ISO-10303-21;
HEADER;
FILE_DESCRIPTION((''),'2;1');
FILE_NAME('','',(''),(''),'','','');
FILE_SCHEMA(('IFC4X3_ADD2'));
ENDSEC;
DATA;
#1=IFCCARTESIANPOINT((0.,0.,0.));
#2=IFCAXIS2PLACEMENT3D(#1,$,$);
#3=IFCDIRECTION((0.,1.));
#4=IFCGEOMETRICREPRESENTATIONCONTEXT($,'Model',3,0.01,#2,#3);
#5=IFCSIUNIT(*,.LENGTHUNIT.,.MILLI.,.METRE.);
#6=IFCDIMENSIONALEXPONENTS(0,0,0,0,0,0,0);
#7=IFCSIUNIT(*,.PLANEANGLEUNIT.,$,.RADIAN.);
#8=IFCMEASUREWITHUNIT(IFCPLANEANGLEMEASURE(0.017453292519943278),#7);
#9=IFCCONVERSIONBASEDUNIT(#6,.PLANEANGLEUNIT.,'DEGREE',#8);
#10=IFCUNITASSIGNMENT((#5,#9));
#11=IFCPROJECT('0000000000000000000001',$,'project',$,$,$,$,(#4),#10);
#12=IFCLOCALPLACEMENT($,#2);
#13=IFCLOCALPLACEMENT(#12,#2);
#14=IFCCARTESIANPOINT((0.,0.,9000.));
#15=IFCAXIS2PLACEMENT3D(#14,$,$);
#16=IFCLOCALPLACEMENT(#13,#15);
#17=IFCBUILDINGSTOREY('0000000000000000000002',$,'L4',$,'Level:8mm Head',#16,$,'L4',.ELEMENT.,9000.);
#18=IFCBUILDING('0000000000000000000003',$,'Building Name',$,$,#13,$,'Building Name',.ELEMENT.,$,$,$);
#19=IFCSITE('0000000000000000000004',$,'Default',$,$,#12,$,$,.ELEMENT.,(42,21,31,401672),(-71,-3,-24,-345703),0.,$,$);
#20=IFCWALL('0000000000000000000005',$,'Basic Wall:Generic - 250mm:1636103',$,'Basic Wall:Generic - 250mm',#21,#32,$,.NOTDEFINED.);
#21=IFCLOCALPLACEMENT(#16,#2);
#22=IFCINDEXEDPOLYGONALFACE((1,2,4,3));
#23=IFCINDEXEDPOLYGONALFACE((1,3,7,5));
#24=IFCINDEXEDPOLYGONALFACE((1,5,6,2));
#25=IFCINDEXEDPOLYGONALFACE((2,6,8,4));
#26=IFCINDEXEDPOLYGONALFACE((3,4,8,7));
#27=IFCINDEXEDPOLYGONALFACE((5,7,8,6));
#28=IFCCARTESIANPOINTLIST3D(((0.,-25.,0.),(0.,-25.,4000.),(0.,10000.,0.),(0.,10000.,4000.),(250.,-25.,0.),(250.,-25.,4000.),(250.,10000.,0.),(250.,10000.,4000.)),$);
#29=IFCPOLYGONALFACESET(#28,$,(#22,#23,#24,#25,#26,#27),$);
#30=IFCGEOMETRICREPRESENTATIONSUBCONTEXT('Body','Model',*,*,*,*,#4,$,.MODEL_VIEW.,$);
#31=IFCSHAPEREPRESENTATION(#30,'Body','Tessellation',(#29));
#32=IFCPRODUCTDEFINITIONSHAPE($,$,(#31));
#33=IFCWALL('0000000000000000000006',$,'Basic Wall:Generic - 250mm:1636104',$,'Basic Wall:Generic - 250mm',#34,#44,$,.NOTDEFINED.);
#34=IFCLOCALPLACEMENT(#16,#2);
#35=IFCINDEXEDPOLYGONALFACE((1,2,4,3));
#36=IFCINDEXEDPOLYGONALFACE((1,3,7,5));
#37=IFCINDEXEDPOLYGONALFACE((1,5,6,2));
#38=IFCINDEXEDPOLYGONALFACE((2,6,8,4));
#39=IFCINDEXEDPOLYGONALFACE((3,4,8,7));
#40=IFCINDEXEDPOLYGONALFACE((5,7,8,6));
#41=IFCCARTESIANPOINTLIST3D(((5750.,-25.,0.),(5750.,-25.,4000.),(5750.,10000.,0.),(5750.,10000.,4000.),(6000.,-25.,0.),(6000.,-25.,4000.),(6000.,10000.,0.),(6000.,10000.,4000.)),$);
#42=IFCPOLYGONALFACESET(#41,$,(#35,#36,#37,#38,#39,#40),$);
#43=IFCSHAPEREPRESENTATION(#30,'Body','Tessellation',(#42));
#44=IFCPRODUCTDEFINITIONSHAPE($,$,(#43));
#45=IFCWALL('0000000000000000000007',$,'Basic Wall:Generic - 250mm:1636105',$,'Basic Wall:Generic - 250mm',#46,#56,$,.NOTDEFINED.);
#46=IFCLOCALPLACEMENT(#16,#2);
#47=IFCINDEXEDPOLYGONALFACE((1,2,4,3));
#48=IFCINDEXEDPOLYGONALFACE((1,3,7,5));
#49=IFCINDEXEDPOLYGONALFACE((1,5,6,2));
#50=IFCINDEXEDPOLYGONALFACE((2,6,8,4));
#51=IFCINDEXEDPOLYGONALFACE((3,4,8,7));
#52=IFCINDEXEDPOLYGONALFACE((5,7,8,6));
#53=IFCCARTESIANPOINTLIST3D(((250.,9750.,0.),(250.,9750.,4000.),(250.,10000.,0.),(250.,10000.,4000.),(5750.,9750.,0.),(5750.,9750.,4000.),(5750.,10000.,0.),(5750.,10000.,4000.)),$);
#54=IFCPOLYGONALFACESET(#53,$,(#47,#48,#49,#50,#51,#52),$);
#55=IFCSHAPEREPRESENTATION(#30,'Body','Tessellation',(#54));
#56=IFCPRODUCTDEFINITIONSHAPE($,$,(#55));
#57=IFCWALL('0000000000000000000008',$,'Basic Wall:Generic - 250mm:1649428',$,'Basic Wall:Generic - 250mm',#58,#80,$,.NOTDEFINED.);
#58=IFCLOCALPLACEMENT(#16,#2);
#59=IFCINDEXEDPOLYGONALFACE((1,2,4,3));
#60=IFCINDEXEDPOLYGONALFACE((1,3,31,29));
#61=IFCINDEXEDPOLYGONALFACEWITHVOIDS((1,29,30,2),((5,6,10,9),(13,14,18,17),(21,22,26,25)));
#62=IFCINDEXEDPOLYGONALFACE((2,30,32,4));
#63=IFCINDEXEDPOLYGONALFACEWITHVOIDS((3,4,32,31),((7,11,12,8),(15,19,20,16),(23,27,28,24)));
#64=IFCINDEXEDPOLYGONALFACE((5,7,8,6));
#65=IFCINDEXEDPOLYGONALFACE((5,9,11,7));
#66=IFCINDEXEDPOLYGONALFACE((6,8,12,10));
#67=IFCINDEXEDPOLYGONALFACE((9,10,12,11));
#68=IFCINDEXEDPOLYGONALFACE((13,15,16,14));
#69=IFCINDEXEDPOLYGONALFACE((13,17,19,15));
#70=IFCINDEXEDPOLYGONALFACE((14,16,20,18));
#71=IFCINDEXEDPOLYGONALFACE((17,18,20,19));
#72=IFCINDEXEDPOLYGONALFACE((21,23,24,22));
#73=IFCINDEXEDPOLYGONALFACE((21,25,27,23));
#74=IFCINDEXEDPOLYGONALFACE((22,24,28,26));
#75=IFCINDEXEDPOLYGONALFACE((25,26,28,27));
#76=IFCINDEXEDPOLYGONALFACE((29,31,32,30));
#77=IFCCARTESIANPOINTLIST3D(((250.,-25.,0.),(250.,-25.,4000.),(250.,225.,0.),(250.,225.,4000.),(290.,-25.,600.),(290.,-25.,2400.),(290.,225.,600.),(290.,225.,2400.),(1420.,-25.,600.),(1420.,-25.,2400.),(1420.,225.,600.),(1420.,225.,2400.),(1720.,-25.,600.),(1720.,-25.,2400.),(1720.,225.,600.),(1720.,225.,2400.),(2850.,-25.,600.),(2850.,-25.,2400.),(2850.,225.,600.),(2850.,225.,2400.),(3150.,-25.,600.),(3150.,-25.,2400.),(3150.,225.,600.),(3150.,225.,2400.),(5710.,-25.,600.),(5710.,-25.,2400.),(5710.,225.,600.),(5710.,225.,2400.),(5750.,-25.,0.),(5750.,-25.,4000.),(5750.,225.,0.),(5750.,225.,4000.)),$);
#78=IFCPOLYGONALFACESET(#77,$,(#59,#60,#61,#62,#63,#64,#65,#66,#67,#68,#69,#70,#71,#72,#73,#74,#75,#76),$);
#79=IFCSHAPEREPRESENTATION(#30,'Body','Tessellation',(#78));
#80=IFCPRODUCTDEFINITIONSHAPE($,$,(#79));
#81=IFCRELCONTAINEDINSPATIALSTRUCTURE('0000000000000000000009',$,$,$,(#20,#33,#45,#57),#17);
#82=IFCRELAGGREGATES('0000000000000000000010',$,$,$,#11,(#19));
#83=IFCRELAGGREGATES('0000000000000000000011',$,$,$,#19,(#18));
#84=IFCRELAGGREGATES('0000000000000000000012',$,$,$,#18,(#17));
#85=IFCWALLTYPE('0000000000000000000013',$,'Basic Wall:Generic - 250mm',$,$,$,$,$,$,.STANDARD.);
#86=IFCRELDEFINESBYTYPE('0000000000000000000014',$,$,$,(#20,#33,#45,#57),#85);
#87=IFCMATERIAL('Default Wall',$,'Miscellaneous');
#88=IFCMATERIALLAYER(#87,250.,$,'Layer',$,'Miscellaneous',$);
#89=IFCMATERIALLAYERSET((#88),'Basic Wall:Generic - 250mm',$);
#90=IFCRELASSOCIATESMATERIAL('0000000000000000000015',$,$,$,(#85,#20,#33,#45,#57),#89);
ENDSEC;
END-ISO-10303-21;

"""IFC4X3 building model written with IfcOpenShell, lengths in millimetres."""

from ifc_helpers import new_model, entity, si_unit, converted_unit, direction, frame, frame_2d, origin, place, context, subcontext, project, spatial, rectangle, extrude, material, layer, layer_set, type_object, element, save


model = new_model("IFC4X3")

# Units and contexts
model_context = context("Model", 3, precision=0.01, world=origin(), true_north=direction((0.0, 1.0)))
body_context = subcontext(model_context, "Body", "Model", "MODEL_VIEW")
ifc_project = project(units=[si_unit("LENGTHUNIT", "METRE", prefix="MILLI"), converted_unit("PLANEANGLEUNIT", "DEGREE", entity("IfcPlaneAngleMeasure", 0.017453292519943278), si_unit("PLANEANGLEUNIT", "RADIAN"), dimensions=[0, 0, 0, 0, 0, 0, 0])], contexts=[model_context])

# Site, building, storey
site_placement = place(None, origin())
site = spatial("IfcSite", under=ifc_project, at=site_placement, Name="Default", CompositionType="ELEMENT", RefLatitude=(42, 21, 31, 401672), RefLongitude=(-71, -3, -24, -345703), RefElevation=0.0)
building_placement = place(site_placement, origin())
building = spatial("IfcBuilding", under=site, at=building_placement, Name="Building Name", LongName="Building Name", CompositionType="ELEMENT")
storey_placement = place(building_placement, frame((0.0, 0.0, 9000.0)))
storey = spatial("IfcBuildingStorey", under=building, at=storey_placement, Name="L4", ObjectType="Level:8mm Head", LongName="L4", CompositionType="ELEMENT", Elevation=9000.0)

# Walls
ifc_material = material(Name="Default Wall", Category="Miscellaneous")
ifc_layer = layer(ifc_material, 250.0, Name="Layer", Category="Miscellaneous")
ifc_layer_set = layer_set([ifc_layer], Name="Basic Wall:Generic - 250mm")
wall_type = type_object("IfcWallType", Name="Basic Wall:Generic - 250mm", PredefinedType="STANDARD", material=ifc_layer_set)
wall_1_placement = place(storey_placement, frame((125.0, 10000.0, 0.0), z_axis=(0.0, 0.0, 1.0), x_axis=(0.0, -1.0, 0.0)))
element("IfcWall", 1, at=wall_1_placement, inside=storey, type_object=wall_type, material=ifc_layer_set, Name="Basic Wall:Generic - 250mm:1636103", ObjectType="Basic Wall:Generic - 250mm", PredefinedType="NOTDEFINED", context=body_context, shape_type="SweptSolid", body=[
    extrude(rectangle(XDim=10025.0, YDim=250.0, at=frame_2d((5012.5, 0.0), x_axis=(-1.0, 0.0))), origin(), (0.0, 0.0, 1.0), 4000.0),
])
wall_2_placement = place(storey_placement, frame((5875.0, -25.0, 0.0), z_axis=(0.0, 0.0, 1.0), x_axis=(0.0, 1.0, 0.0)))
element("IfcWall", 2, at=wall_2_placement, inside=storey, type_object=wall_type, material=ifc_layer_set, Name="Basic Wall:Generic - 250mm:1636104", ObjectType="Basic Wall:Generic - 250mm", PredefinedType="NOTDEFINED", context=body_context, shape_type="SweptSolid", body=[
    extrude(rectangle(XDim=10025.0, YDim=250.0, at=frame_2d((5012.5, 0.0), x_axis=(-1.0, 0.0))), origin(), (0.0, 0.0, 1.0), 4000.0),
])
wall_3_placement = place(storey_placement, frame((5750.0, 9875.0, 0.0), z_axis=(0.0, 0.0, 1.0), x_axis=(-1.0, 0.0, 0.0)))
element("IfcWall", 3, at=wall_3_placement, inside=storey, type_object=wall_type, material=ifc_layer_set, Name="Basic Wall:Generic - 250mm:1636105", ObjectType="Basic Wall:Generic - 250mm", PredefinedType="NOTDEFINED", context=body_context, shape_type="SweptSolid", body=[
    extrude(rectangle(XDim=5500.0, YDim=250.0, at=frame_2d((2750.0, 0.0), x_axis=(-1.0, 0.0))), origin(), (0.0, 0.0, 1.0), 4000.0),
])

# Wall, openings
wall_4_placement = place(storey_placement, frame((250.0, 100.0, 0.0)))
wall_4 = element("IfcWall", 4, at=wall_4_placement, inside=storey, type_object=wall_type, material=ifc_layer_set, Name="Basic Wall:Generic - 250mm:1649428", ObjectType="Basic Wall:Generic - 250mm", PredefinedType="NOTDEFINED", context=body_context, shape_type="SweptSolid", body=[
    extrude(rectangle(XDim=5500.0, YDim=250.0, at=frame_2d((2750.0, 0.0), x_axis=(-1.0, 0.0))), origin(), (0.0, 0.0, 1.0), 4000.0),
])
opening_1_placement = place(wall_4_placement, frame((1470.0, -125.0, 600.0)))
element("IfcOpeningElement", 5, at=opening_1_placement, cuts=wall_4, PredefinedType="OPENING", context=body_context, shape_type="SweptSolid", body=[
    extrude(rectangle(XDim=1800.0, YDim=1130.0, at=frame_2d((900.0, 565.0), x_axis=(-1.0, 0.0))), frame((0.0, 0.0, 0.0), z_axis=(0.0, 1.0, 0.0), x_axis=(0.0, 0.0, 1.0)), (0.0, 0.0, 1.0), 250.0),
])
opening_2_placement = place(wall_4_placement, frame((2900.0, -125.0, 600.0)))
element("IfcOpeningElement", 6, at=opening_2_placement, cuts=wall_4, PredefinedType="OPENING", context=body_context, shape_type="SweptSolid", body=[
    extrude(rectangle(XDim=1800.0, YDim=2560.0, at=frame_2d((900.0, 1280.0), x_axis=(-1.0, 0.0))), frame((0.0, 0.0, 0.0), z_axis=(0.0, 1.0, 0.0), x_axis=(0.0, 0.0, 1.0)), (0.0, 0.0, 1.0), 250.0),
])
opening_3_placement = place(wall_4_placement, frame((40.0, -125.0, 600.0)))
element("IfcOpeningElement", 7, at=opening_3_placement, cuts=wall_4, PredefinedType="OPENING", context=body_context, shape_type="SweptSolid", body=[
    extrude(rectangle(XDim=1800.0, YDim=1130.0, at=frame_2d((900.0, 565.0), x_axis=(-1.0, 0.0))), frame((0.0, 0.0, 0.0), z_axis=(0.0, 1.0, 0.0), x_axis=(0.0, 0.0, 1.0)), (0.0, 0.0, 1.0), 250.0),
])

save(model, "model.ifc")
